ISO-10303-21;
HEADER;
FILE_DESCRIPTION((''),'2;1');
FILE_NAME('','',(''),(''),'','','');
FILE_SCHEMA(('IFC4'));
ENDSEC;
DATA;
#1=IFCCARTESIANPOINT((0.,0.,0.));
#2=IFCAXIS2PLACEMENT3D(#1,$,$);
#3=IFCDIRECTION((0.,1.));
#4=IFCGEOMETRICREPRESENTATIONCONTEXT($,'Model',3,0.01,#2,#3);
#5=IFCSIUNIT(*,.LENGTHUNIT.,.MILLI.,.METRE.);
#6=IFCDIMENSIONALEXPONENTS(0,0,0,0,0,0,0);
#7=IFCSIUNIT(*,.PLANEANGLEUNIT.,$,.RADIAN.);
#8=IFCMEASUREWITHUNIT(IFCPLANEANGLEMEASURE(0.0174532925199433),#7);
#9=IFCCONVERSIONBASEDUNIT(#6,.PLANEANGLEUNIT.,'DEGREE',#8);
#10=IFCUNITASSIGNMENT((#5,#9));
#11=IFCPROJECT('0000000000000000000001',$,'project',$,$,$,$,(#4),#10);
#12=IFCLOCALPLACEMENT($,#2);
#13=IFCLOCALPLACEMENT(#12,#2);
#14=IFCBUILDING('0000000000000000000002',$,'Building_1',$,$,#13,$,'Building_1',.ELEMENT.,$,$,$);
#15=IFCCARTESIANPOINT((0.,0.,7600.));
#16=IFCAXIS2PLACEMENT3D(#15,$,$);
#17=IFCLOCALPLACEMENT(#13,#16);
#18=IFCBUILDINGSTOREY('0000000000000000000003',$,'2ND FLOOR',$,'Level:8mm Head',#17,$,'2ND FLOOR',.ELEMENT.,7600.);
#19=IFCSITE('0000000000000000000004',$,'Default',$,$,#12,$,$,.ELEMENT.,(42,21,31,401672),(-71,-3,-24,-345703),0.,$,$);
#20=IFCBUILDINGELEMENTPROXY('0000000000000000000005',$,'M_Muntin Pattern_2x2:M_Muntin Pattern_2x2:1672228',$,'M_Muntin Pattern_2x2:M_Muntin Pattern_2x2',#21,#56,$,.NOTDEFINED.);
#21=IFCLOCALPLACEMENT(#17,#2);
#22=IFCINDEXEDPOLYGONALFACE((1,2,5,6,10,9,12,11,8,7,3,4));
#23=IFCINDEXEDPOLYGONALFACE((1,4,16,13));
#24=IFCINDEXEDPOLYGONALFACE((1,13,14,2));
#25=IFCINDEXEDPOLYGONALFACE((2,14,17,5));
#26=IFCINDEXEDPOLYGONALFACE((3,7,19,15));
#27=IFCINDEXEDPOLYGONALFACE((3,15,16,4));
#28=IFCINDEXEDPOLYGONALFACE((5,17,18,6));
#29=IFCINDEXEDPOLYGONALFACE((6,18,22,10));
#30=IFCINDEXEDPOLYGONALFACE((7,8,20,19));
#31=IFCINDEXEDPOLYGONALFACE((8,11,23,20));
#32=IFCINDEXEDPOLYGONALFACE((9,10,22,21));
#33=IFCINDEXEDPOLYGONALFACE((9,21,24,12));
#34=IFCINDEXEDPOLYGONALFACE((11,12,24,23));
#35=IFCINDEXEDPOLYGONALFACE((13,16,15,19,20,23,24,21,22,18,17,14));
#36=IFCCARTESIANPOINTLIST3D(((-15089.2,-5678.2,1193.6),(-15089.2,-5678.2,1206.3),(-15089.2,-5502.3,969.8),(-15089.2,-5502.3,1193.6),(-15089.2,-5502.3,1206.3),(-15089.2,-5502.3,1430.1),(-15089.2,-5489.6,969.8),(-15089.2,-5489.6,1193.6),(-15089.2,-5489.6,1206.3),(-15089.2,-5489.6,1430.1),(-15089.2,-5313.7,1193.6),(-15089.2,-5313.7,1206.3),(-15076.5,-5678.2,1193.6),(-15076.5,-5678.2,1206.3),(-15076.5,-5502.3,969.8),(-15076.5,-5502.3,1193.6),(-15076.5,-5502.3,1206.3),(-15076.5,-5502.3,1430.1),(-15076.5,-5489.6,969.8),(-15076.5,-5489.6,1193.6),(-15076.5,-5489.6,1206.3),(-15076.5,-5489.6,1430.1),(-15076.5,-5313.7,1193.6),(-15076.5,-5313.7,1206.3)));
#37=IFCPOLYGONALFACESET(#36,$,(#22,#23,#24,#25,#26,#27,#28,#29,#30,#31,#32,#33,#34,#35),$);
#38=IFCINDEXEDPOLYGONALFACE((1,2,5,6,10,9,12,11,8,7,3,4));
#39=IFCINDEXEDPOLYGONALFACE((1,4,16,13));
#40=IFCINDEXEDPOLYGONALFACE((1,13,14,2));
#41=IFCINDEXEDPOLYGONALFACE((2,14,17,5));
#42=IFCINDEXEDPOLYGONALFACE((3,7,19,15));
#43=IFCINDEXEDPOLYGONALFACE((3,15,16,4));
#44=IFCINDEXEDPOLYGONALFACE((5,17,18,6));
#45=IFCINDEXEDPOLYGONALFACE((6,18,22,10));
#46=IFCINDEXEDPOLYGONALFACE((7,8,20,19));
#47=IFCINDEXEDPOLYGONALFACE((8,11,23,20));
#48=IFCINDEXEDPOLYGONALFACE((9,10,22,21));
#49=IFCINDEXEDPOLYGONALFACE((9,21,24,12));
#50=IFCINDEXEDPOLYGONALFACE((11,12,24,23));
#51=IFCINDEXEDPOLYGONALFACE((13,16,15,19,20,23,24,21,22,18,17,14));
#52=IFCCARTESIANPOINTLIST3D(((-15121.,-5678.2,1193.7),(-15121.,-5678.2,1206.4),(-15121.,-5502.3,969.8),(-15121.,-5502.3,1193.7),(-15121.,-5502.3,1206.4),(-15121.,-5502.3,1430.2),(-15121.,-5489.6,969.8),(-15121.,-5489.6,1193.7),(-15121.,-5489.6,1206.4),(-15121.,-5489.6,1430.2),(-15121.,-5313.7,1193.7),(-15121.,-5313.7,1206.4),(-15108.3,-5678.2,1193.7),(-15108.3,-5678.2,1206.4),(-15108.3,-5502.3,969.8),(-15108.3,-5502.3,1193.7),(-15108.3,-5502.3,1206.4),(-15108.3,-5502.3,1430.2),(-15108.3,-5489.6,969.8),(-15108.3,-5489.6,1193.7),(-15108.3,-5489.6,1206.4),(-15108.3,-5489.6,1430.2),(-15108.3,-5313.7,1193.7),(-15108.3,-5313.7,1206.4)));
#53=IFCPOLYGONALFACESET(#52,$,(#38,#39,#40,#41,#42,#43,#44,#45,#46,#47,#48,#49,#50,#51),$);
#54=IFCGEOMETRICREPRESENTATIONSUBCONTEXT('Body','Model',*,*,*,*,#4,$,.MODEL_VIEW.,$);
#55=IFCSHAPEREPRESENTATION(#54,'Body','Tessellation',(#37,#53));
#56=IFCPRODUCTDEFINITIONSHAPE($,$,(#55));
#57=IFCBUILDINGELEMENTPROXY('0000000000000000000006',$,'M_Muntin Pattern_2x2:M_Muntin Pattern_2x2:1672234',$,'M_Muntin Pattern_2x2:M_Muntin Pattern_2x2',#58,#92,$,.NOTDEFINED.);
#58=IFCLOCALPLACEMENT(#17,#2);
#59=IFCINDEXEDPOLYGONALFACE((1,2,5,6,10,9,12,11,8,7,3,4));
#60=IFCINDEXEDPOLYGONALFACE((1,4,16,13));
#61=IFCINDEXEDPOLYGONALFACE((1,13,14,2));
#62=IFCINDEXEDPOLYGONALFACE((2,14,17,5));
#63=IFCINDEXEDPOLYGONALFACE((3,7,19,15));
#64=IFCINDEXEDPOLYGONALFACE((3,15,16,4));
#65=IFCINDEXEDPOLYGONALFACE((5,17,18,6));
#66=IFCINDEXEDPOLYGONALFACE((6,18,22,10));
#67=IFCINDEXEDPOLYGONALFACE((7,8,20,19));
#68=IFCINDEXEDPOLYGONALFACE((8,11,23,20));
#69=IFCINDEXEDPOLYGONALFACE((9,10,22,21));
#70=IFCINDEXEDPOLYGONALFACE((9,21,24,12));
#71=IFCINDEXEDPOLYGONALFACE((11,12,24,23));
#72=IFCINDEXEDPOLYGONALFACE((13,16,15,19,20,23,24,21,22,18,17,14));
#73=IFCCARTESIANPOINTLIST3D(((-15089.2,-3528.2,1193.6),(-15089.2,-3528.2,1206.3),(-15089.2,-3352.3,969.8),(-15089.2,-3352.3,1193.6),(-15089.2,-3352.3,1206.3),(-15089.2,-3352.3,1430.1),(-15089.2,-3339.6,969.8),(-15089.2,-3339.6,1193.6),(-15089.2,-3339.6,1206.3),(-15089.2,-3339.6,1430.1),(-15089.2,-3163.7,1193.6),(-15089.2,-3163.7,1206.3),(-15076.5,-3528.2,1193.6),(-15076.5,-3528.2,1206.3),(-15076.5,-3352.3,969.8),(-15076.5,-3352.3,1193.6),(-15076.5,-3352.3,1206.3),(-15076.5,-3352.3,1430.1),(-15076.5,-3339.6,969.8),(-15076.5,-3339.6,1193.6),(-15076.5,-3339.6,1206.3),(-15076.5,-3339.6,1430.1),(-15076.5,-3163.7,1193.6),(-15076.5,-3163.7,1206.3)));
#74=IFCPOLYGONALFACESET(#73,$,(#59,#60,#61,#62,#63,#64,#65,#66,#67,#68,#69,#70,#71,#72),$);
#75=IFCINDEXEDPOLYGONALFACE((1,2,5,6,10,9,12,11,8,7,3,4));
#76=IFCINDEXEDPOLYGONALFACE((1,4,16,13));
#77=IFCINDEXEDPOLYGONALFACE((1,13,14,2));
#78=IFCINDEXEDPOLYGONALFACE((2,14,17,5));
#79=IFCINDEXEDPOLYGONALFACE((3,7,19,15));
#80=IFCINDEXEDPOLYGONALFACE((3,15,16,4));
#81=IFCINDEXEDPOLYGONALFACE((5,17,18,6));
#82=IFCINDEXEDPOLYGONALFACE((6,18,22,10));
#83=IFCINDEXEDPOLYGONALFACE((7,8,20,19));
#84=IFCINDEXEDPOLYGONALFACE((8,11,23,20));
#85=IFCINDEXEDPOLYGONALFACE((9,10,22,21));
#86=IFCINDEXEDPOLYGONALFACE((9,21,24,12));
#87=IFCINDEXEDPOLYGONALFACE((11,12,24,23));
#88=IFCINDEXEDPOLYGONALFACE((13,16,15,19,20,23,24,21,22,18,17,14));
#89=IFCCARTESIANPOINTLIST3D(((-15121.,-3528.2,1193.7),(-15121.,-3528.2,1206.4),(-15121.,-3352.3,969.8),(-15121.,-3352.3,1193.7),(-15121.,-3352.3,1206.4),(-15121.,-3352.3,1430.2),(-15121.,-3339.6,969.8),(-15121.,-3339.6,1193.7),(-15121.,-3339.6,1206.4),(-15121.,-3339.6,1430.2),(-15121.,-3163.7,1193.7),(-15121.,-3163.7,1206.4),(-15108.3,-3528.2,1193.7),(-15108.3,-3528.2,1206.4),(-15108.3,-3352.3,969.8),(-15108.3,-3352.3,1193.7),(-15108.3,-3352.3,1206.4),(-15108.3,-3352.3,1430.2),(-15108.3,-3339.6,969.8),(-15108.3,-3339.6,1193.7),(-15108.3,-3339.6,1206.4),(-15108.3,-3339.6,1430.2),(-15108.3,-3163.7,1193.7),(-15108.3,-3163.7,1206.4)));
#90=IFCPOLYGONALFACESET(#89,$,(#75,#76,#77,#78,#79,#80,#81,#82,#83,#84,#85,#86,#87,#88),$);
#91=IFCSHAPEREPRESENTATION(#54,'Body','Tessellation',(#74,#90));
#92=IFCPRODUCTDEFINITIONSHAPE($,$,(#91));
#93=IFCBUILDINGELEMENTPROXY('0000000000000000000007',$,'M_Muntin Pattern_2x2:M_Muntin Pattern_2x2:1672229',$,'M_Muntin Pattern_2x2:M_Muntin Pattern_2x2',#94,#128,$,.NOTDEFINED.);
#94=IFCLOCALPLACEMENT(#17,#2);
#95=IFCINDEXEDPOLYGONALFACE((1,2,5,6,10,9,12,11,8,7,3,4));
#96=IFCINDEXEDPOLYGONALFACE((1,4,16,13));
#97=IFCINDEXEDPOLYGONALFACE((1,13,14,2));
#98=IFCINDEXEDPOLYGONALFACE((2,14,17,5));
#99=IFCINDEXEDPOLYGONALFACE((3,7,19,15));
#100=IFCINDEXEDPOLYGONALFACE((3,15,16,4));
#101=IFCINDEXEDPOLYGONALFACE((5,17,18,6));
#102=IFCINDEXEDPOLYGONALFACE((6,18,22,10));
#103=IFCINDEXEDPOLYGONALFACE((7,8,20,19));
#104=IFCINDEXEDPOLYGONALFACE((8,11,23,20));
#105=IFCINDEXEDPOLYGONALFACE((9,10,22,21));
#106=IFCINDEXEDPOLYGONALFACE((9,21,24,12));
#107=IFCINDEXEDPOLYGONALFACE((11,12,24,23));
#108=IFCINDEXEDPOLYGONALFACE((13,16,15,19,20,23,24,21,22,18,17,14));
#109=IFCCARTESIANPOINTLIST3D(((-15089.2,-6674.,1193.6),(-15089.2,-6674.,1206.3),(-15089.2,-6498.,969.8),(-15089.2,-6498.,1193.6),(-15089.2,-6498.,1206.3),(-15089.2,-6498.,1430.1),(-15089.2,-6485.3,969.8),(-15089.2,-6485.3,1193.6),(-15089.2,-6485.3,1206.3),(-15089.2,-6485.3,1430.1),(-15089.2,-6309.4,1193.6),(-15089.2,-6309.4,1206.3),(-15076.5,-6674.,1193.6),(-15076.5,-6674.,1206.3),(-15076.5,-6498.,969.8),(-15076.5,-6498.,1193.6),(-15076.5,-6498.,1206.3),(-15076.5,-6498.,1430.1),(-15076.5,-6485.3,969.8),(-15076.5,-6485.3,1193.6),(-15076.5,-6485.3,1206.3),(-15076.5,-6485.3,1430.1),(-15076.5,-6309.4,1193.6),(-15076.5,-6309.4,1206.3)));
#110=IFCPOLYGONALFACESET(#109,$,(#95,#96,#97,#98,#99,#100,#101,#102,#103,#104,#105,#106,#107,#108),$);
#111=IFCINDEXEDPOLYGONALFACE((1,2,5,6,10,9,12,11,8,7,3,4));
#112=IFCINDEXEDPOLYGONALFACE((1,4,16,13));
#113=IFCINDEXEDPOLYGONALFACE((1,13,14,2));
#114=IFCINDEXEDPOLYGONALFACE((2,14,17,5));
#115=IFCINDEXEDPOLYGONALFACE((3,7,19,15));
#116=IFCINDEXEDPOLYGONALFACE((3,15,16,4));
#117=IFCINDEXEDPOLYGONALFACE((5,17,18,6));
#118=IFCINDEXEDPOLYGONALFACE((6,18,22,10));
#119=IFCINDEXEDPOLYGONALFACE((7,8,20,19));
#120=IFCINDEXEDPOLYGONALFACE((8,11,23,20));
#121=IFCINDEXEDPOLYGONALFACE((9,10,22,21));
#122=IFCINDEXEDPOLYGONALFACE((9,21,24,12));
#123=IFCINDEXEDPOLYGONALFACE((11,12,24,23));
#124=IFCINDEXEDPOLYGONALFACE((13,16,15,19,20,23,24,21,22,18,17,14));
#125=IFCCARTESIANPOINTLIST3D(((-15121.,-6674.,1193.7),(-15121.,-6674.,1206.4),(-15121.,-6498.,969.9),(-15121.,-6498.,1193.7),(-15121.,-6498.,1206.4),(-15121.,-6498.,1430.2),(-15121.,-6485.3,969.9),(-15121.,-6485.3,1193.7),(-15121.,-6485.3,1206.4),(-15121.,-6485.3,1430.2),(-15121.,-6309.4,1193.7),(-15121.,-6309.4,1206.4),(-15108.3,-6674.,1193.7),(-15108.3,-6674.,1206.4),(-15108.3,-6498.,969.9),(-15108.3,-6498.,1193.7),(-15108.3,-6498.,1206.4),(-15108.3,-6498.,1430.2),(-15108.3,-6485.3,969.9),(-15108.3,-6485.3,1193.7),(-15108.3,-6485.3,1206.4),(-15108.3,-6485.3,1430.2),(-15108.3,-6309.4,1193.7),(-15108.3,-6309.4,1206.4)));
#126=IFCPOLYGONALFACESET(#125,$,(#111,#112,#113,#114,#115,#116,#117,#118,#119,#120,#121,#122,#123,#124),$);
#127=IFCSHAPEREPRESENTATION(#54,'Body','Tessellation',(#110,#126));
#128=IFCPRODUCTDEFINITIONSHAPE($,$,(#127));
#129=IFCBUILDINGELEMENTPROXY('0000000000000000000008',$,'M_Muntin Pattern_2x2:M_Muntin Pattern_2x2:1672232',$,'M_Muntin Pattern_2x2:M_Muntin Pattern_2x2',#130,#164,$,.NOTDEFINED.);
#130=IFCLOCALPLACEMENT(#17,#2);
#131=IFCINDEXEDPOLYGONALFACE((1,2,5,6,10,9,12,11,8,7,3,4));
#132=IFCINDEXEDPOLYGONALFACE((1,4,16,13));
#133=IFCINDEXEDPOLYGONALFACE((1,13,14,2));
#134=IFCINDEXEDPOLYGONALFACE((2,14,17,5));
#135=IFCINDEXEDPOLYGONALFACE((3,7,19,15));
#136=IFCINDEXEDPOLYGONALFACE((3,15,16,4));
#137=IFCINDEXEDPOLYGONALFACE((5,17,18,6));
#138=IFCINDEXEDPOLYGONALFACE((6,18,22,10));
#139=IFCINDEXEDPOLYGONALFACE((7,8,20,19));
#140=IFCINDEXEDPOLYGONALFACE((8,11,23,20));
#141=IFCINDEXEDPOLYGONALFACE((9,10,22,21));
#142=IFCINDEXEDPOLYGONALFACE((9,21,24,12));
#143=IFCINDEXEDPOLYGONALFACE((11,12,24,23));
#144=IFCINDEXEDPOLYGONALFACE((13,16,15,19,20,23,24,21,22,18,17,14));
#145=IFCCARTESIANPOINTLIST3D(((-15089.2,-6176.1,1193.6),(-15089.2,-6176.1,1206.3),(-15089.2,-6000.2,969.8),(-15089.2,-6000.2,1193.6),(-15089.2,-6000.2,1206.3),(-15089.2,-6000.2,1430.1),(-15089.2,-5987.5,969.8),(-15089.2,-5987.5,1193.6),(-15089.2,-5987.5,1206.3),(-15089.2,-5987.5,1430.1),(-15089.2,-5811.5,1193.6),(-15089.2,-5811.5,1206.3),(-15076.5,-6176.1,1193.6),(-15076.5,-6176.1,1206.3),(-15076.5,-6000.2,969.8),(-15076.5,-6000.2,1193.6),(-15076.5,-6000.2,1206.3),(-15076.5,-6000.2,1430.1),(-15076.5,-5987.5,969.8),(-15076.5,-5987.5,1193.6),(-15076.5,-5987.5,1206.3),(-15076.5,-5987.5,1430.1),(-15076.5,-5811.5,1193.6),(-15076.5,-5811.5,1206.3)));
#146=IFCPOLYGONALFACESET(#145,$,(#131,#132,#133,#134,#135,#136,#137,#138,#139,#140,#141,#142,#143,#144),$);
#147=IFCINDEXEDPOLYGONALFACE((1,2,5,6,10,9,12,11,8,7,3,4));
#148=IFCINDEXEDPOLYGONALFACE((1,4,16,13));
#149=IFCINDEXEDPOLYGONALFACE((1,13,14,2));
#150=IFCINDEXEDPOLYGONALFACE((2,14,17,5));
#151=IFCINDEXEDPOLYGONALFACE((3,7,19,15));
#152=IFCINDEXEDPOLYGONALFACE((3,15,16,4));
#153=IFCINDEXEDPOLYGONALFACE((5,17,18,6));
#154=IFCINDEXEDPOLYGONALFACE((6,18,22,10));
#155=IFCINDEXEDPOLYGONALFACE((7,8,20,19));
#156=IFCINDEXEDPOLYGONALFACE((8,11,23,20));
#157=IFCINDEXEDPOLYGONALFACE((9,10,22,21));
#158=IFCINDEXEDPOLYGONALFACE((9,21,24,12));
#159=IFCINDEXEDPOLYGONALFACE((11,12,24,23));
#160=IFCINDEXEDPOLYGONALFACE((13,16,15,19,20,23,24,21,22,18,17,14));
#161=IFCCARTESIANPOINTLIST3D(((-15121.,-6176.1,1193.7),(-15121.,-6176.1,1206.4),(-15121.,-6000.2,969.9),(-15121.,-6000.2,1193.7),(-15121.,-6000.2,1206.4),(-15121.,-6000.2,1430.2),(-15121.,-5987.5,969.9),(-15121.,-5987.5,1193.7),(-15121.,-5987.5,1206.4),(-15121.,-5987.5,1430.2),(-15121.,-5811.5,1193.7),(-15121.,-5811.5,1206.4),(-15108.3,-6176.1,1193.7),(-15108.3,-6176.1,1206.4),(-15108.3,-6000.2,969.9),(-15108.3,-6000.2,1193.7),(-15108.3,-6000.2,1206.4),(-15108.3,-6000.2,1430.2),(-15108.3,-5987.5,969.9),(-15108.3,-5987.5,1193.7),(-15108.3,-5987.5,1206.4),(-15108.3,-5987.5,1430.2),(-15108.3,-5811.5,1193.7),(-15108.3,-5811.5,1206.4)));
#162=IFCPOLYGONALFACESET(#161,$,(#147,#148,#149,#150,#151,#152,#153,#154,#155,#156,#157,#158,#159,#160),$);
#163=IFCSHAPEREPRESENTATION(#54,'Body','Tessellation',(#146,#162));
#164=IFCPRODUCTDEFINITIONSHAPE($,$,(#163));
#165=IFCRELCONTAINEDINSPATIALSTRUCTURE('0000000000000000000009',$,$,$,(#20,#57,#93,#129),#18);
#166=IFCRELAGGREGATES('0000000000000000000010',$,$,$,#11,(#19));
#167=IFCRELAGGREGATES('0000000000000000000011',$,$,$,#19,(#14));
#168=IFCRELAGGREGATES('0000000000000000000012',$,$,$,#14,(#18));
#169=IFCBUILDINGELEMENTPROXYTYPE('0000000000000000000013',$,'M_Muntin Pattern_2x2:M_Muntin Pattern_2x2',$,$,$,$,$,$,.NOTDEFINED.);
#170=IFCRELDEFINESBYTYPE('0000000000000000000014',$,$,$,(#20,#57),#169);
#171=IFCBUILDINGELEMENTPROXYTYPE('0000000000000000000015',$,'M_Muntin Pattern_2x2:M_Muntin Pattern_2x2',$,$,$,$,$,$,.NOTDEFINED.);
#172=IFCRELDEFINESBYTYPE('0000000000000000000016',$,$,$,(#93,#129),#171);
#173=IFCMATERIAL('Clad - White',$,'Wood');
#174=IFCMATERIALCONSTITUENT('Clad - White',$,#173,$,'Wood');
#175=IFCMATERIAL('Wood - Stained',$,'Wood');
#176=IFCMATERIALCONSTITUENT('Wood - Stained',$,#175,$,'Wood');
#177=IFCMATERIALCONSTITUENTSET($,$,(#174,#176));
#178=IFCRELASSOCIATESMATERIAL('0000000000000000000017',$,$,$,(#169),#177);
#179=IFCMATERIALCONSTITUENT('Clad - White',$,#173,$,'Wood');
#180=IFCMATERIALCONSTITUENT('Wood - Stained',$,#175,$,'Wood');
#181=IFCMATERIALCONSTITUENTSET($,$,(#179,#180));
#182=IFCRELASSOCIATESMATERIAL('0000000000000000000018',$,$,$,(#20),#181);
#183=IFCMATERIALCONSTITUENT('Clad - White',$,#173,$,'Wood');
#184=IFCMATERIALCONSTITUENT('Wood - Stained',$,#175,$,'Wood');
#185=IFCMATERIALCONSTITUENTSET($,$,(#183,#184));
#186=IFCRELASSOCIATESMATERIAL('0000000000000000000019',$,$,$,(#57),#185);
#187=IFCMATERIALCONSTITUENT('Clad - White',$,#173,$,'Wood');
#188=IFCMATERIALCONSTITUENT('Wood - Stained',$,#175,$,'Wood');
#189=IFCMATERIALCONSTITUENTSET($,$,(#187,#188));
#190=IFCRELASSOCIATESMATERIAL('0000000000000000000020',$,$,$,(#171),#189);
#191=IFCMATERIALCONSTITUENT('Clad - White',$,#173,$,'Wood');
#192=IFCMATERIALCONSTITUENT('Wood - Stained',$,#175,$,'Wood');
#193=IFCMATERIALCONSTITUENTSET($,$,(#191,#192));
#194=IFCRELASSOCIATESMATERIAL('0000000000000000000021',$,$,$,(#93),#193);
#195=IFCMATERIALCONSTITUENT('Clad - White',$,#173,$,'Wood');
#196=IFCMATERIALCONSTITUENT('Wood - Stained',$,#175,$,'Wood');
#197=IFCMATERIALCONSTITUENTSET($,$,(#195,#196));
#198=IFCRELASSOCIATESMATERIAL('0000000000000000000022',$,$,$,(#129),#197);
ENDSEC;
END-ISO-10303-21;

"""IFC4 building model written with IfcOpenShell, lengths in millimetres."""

from ifc_helpers import new_model, entity, si_unit, converted_unit, direction, frame, origin, place, context, subcontext, project, spatial, indexed_curve, outline, extrude, source, transform, mapped, material, constituent, constituent_set, type_object, type_shapes, element, save


model = new_model("IFC4")

# Units and contexts
model_context = context("Model", 3, precision=0.01, world=origin(), true_north=direction((0.0, 1.0)))
body_context = subcontext(model_context, "Body", "Model", "MODEL_VIEW")
ifc_project = project(units=[si_unit("LENGTHUNIT", "METRE", prefix="MILLI"), converted_unit("PLANEANGLEUNIT", "DEGREE", entity("IfcPlaneAngleMeasure", 0.0174532925199433), si_unit("PLANEANGLEUNIT", "RADIAN"), dimensions=[0, 0, 0, 0, 0, 0, 0])], contexts=[model_context])

# Site, building, storey
site_placement = place(None, origin())
site = spatial("IfcSite", under=ifc_project, at=site_placement, Name="Default", CompositionType="ELEMENT", RefLatitude=(42, 21, 31, 401672), RefLongitude=(-71, -3, -24, -345703), RefElevation=0.0)
building_placement = place(site_placement, origin())
building = spatial("IfcBuilding", under=site, at=building_placement, Name="Building_1", LongName="Building_1", CompositionType="ELEMENT")
storey_placement = place(building_placement, frame((0.0, 0.0, 7600.0)))
storey = spatial("IfcBuildingStorey", under=building, at=storey_placement, Name="2ND FLOOR", ObjectType="Level:8mm Head", LongName="2ND FLOOR", CompositionType="ELEMENT", Elevation=7600.0)

# Shared definitions
ifc_material_1 = material(Name="Wood - Stained", Category="Wood")

# Building element proxies
ifc_material_2 = material(Name="Clad - White", Category="Wood")
ifc_constituent_1 = constituent(ifc_material_2, Name="Clad - White", Category="Wood")
ifc_constituent_2 = constituent(ifc_material_1, Name="Wood - Stained", Category="Wood")
ifc_constituent_set_1 = constituent_set(constituents=[ifc_constituent_1, ifc_constituent_2])
ifc_constituent_3 = constituent(ifc_material_2, Name="Clad - White", Category="Wood")
ifc_constituent_4 = constituent(ifc_material_1, Name="Wood - Stained", Category="Wood")
ifc_constituent_set_2 = constituent_set(constituents=[ifc_constituent_3, ifc_constituent_4])
building_element_proxy_type_1 = type_object("IfcBuildingElementProxyType", Name="M_Muntin Pattern_2x2:M_Muntin Pattern_2x2", PredefinedType="NOTDEFINED", material=ifc_constituent_set_2)
shared_shape_1 = source(origin(), body_context, "Body", "SweptSolid", [
    extrude(outline(indexed_curve([(6.4, -6.4), (230.1, -6.4), (230.1, 6.3), (6.4, 6.3), (6.4, 182.3), (-6.3, 182.3), (-6.3, 6.3), (-230.2, 6.3), (-230.2, -6.4), (-6.3, -6.4), (-6.3, -182.3), (6.4, -182.3), (6.4, -6.4)], self_intersect=False)), frame((0.0, 9.5, 230.1), z_axis=(0.0, 1.0, 0.0), x_axis=(0.0, 0.0, 1.0)), (0.0, 0.0, 1.0), 12.7),
    extrude(outline(indexed_curve([(6.4, -6.4), (230.2, -6.4), (230.2, 6.3), (6.4, 6.3), (6.4, 182.3), (-6.3, 182.3), (-6.3, 6.3), (-230.2, 6.3), (-230.2, -6.4), (-6.3, -6.4), (-6.3, -182.3), (6.4, -182.3), (6.4, -6.4)], self_intersect=False)), frame((0.0, -22.2, 230.2), z_axis=(0.0, 1.0, 0.0), x_axis=(0.0, 0.0, 1.0)), (0.0, 0.0, 1.0), 12.7),
])
type_shapes(building_element_proxy_type_1, [shared_shape_1])
proxy_1_placement = place(storey_placement, frame((-15098.7, -5495.9, 969.8), z_axis=(0.0, 0.0, 1.0), x_axis=(0.0, -1.0, 0.0)))
element("IfcBuildingElementProxy", 1, at=proxy_1_placement, inside=storey, type_object=building_element_proxy_type_1, material=ifc_constituent_set_1, Name="M_Muntin Pattern_2x2:M_Muntin Pattern_2x2:1672228", ObjectType="M_Muntin Pattern_2x2:M_Muntin Pattern_2x2", PredefinedType="NOTDEFINED", context=body_context, shape_type="MappedRepresentation", body=[
    mapped(shared_shape_1, transform((0.0, 0.0, 0.0), scale=1.0)),
])
ifc_constituent_5 = constituent(ifc_material_2, Name="Clad - White", Category="Wood")
ifc_constituent_6 = constituent(ifc_material_1, Name="Wood - Stained", Category="Wood")
ifc_constituent_set_3 = constituent_set(constituents=[ifc_constituent_5, ifc_constituent_6])
proxy_2_placement = place(storey_placement, frame((-15098.7, -3345.9, 969.8), z_axis=(0.0, 0.0, 1.0), x_axis=(0.0, -1.0, 0.0)))
element("IfcBuildingElementProxy", 2, at=proxy_2_placement, inside=storey, type_object=building_element_proxy_type_1, material=ifc_constituent_set_3, Name="M_Muntin Pattern_2x2:M_Muntin Pattern_2x2:1672234", ObjectType="M_Muntin Pattern_2x2:M_Muntin Pattern_2x2", PredefinedType="NOTDEFINED", context=body_context, shape_type="MappedRepresentation", body=[
    mapped(shared_shape_1, transform((0.0, 0.0, 0.0), scale=1.0)),
])
ifc_constituent_7 = constituent(ifc_material_2, Name="Clad - White", Category="Wood")
ifc_constituent_8 = constituent(ifc_material_1, Name="Wood - Stained", Category="Wood")
ifc_constituent_set_4 = constituent_set(constituents=[ifc_constituent_7, ifc_constituent_8])
ifc_constituent_9 = constituent(ifc_material_2, Name="Clad - White", Category="Wood")
ifc_constituent_10 = constituent(ifc_material_1, Name="Wood - Stained", Category="Wood")
ifc_constituent_set_5 = constituent_set(constituents=[ifc_constituent_9, ifc_constituent_10])
building_element_proxy_type_2 = type_object("IfcBuildingElementProxyType", Name="M_Muntin Pattern_2x2:M_Muntin Pattern_2x2", PredefinedType="NOTDEFINED", material=ifc_constituent_set_5)
shared_shape_2 = source(origin(), body_context, "Body", "SweptSolid", [
    extrude(outline(indexed_curve([(6.4, -6.4), (230.1, -6.4), (230.1, 6.3), (6.4, 6.3), (6.4, 182.3), (-6.3, 182.3), (-6.3, 6.3), (-230.2, 6.3), (-230.2, -6.4), (-6.3, -6.4), (-6.3, -182.3), (6.4, -182.3), (6.4, -6.4)], self_intersect=False)), frame((0.0, -22.2, 230.1), z_axis=(0.0, 1.0, 0.0), x_axis=(0.0, 0.0, 1.0)), (0.0, 0.0, 1.0), 12.7),
    extrude(outline(indexed_curve([(6.4, -6.4), (230.2, -6.4), (230.2, 6.3), (6.4, 6.3), (6.4, 182.3), (-6.3, 182.3), (-6.3, 6.3), (-230.2, 6.3), (-230.2, -6.4), (-6.3, -6.4), (-6.3, -182.3), (6.4, -182.3), (6.4, -6.4)], self_intersect=False)), frame((0.0, 9.5, 230.2), z_axis=(0.0, 1.0, 0.0), x_axis=(0.0, 0.0, 1.0)), (0.0, 0.0, 1.0), 12.7),
])
type_shapes(building_element_proxy_type_2, [shared_shape_2])
proxy_3_placement = place(storey_placement, frame((-15098.7, -6491.7, 969.9), z_axis=(0.0, 0.0, 1.0), x_axis=(0.0, 1.0, 0.0)))
element("IfcBuildingElementProxy", 3, at=proxy_3_placement, inside=storey, type_object=building_element_proxy_type_2, material=ifc_constituent_set_4, Name="M_Muntin Pattern_2x2:M_Muntin Pattern_2x2:1672229", ObjectType="M_Muntin Pattern_2x2:M_Muntin Pattern_2x2", PredefinedType="NOTDEFINED", context=body_context, shape_type="MappedRepresentation", body=[
    mapped(shared_shape_2, transform((0.0, 0.0, 0.0), scale=1.0)),
])
ifc_constituent_11 = constituent(ifc_material_2, Name="Clad - White", Category="Wood")
ifc_constituent_12 = constituent(ifc_material_1, Name="Wood - Stained", Category="Wood")
ifc_constituent_set_6 = constituent_set(constituents=[ifc_constituent_11, ifc_constituent_12])
proxy_4_placement = place(storey_placement, frame((-15098.7, -5993.8, 969.9), z_axis=(0.0, 0.0, 1.0), x_axis=(0.0, 1.0, 0.0)))
element("IfcBuildingElementProxy", 4, at=proxy_4_placement, inside=storey, type_object=building_element_proxy_type_2, material=ifc_constituent_set_6, Name="M_Muntin Pattern_2x2:M_Muntin Pattern_2x2:1672232", ObjectType="M_Muntin Pattern_2x2:M_Muntin Pattern_2x2", PredefinedType="NOTDEFINED", context=body_context, shape_type="MappedRepresentation", body=[
    mapped(shared_shape_2, transform((0.0, 0.0, 0.0), scale=1.0)),
])

save(model, "model.ifc")
